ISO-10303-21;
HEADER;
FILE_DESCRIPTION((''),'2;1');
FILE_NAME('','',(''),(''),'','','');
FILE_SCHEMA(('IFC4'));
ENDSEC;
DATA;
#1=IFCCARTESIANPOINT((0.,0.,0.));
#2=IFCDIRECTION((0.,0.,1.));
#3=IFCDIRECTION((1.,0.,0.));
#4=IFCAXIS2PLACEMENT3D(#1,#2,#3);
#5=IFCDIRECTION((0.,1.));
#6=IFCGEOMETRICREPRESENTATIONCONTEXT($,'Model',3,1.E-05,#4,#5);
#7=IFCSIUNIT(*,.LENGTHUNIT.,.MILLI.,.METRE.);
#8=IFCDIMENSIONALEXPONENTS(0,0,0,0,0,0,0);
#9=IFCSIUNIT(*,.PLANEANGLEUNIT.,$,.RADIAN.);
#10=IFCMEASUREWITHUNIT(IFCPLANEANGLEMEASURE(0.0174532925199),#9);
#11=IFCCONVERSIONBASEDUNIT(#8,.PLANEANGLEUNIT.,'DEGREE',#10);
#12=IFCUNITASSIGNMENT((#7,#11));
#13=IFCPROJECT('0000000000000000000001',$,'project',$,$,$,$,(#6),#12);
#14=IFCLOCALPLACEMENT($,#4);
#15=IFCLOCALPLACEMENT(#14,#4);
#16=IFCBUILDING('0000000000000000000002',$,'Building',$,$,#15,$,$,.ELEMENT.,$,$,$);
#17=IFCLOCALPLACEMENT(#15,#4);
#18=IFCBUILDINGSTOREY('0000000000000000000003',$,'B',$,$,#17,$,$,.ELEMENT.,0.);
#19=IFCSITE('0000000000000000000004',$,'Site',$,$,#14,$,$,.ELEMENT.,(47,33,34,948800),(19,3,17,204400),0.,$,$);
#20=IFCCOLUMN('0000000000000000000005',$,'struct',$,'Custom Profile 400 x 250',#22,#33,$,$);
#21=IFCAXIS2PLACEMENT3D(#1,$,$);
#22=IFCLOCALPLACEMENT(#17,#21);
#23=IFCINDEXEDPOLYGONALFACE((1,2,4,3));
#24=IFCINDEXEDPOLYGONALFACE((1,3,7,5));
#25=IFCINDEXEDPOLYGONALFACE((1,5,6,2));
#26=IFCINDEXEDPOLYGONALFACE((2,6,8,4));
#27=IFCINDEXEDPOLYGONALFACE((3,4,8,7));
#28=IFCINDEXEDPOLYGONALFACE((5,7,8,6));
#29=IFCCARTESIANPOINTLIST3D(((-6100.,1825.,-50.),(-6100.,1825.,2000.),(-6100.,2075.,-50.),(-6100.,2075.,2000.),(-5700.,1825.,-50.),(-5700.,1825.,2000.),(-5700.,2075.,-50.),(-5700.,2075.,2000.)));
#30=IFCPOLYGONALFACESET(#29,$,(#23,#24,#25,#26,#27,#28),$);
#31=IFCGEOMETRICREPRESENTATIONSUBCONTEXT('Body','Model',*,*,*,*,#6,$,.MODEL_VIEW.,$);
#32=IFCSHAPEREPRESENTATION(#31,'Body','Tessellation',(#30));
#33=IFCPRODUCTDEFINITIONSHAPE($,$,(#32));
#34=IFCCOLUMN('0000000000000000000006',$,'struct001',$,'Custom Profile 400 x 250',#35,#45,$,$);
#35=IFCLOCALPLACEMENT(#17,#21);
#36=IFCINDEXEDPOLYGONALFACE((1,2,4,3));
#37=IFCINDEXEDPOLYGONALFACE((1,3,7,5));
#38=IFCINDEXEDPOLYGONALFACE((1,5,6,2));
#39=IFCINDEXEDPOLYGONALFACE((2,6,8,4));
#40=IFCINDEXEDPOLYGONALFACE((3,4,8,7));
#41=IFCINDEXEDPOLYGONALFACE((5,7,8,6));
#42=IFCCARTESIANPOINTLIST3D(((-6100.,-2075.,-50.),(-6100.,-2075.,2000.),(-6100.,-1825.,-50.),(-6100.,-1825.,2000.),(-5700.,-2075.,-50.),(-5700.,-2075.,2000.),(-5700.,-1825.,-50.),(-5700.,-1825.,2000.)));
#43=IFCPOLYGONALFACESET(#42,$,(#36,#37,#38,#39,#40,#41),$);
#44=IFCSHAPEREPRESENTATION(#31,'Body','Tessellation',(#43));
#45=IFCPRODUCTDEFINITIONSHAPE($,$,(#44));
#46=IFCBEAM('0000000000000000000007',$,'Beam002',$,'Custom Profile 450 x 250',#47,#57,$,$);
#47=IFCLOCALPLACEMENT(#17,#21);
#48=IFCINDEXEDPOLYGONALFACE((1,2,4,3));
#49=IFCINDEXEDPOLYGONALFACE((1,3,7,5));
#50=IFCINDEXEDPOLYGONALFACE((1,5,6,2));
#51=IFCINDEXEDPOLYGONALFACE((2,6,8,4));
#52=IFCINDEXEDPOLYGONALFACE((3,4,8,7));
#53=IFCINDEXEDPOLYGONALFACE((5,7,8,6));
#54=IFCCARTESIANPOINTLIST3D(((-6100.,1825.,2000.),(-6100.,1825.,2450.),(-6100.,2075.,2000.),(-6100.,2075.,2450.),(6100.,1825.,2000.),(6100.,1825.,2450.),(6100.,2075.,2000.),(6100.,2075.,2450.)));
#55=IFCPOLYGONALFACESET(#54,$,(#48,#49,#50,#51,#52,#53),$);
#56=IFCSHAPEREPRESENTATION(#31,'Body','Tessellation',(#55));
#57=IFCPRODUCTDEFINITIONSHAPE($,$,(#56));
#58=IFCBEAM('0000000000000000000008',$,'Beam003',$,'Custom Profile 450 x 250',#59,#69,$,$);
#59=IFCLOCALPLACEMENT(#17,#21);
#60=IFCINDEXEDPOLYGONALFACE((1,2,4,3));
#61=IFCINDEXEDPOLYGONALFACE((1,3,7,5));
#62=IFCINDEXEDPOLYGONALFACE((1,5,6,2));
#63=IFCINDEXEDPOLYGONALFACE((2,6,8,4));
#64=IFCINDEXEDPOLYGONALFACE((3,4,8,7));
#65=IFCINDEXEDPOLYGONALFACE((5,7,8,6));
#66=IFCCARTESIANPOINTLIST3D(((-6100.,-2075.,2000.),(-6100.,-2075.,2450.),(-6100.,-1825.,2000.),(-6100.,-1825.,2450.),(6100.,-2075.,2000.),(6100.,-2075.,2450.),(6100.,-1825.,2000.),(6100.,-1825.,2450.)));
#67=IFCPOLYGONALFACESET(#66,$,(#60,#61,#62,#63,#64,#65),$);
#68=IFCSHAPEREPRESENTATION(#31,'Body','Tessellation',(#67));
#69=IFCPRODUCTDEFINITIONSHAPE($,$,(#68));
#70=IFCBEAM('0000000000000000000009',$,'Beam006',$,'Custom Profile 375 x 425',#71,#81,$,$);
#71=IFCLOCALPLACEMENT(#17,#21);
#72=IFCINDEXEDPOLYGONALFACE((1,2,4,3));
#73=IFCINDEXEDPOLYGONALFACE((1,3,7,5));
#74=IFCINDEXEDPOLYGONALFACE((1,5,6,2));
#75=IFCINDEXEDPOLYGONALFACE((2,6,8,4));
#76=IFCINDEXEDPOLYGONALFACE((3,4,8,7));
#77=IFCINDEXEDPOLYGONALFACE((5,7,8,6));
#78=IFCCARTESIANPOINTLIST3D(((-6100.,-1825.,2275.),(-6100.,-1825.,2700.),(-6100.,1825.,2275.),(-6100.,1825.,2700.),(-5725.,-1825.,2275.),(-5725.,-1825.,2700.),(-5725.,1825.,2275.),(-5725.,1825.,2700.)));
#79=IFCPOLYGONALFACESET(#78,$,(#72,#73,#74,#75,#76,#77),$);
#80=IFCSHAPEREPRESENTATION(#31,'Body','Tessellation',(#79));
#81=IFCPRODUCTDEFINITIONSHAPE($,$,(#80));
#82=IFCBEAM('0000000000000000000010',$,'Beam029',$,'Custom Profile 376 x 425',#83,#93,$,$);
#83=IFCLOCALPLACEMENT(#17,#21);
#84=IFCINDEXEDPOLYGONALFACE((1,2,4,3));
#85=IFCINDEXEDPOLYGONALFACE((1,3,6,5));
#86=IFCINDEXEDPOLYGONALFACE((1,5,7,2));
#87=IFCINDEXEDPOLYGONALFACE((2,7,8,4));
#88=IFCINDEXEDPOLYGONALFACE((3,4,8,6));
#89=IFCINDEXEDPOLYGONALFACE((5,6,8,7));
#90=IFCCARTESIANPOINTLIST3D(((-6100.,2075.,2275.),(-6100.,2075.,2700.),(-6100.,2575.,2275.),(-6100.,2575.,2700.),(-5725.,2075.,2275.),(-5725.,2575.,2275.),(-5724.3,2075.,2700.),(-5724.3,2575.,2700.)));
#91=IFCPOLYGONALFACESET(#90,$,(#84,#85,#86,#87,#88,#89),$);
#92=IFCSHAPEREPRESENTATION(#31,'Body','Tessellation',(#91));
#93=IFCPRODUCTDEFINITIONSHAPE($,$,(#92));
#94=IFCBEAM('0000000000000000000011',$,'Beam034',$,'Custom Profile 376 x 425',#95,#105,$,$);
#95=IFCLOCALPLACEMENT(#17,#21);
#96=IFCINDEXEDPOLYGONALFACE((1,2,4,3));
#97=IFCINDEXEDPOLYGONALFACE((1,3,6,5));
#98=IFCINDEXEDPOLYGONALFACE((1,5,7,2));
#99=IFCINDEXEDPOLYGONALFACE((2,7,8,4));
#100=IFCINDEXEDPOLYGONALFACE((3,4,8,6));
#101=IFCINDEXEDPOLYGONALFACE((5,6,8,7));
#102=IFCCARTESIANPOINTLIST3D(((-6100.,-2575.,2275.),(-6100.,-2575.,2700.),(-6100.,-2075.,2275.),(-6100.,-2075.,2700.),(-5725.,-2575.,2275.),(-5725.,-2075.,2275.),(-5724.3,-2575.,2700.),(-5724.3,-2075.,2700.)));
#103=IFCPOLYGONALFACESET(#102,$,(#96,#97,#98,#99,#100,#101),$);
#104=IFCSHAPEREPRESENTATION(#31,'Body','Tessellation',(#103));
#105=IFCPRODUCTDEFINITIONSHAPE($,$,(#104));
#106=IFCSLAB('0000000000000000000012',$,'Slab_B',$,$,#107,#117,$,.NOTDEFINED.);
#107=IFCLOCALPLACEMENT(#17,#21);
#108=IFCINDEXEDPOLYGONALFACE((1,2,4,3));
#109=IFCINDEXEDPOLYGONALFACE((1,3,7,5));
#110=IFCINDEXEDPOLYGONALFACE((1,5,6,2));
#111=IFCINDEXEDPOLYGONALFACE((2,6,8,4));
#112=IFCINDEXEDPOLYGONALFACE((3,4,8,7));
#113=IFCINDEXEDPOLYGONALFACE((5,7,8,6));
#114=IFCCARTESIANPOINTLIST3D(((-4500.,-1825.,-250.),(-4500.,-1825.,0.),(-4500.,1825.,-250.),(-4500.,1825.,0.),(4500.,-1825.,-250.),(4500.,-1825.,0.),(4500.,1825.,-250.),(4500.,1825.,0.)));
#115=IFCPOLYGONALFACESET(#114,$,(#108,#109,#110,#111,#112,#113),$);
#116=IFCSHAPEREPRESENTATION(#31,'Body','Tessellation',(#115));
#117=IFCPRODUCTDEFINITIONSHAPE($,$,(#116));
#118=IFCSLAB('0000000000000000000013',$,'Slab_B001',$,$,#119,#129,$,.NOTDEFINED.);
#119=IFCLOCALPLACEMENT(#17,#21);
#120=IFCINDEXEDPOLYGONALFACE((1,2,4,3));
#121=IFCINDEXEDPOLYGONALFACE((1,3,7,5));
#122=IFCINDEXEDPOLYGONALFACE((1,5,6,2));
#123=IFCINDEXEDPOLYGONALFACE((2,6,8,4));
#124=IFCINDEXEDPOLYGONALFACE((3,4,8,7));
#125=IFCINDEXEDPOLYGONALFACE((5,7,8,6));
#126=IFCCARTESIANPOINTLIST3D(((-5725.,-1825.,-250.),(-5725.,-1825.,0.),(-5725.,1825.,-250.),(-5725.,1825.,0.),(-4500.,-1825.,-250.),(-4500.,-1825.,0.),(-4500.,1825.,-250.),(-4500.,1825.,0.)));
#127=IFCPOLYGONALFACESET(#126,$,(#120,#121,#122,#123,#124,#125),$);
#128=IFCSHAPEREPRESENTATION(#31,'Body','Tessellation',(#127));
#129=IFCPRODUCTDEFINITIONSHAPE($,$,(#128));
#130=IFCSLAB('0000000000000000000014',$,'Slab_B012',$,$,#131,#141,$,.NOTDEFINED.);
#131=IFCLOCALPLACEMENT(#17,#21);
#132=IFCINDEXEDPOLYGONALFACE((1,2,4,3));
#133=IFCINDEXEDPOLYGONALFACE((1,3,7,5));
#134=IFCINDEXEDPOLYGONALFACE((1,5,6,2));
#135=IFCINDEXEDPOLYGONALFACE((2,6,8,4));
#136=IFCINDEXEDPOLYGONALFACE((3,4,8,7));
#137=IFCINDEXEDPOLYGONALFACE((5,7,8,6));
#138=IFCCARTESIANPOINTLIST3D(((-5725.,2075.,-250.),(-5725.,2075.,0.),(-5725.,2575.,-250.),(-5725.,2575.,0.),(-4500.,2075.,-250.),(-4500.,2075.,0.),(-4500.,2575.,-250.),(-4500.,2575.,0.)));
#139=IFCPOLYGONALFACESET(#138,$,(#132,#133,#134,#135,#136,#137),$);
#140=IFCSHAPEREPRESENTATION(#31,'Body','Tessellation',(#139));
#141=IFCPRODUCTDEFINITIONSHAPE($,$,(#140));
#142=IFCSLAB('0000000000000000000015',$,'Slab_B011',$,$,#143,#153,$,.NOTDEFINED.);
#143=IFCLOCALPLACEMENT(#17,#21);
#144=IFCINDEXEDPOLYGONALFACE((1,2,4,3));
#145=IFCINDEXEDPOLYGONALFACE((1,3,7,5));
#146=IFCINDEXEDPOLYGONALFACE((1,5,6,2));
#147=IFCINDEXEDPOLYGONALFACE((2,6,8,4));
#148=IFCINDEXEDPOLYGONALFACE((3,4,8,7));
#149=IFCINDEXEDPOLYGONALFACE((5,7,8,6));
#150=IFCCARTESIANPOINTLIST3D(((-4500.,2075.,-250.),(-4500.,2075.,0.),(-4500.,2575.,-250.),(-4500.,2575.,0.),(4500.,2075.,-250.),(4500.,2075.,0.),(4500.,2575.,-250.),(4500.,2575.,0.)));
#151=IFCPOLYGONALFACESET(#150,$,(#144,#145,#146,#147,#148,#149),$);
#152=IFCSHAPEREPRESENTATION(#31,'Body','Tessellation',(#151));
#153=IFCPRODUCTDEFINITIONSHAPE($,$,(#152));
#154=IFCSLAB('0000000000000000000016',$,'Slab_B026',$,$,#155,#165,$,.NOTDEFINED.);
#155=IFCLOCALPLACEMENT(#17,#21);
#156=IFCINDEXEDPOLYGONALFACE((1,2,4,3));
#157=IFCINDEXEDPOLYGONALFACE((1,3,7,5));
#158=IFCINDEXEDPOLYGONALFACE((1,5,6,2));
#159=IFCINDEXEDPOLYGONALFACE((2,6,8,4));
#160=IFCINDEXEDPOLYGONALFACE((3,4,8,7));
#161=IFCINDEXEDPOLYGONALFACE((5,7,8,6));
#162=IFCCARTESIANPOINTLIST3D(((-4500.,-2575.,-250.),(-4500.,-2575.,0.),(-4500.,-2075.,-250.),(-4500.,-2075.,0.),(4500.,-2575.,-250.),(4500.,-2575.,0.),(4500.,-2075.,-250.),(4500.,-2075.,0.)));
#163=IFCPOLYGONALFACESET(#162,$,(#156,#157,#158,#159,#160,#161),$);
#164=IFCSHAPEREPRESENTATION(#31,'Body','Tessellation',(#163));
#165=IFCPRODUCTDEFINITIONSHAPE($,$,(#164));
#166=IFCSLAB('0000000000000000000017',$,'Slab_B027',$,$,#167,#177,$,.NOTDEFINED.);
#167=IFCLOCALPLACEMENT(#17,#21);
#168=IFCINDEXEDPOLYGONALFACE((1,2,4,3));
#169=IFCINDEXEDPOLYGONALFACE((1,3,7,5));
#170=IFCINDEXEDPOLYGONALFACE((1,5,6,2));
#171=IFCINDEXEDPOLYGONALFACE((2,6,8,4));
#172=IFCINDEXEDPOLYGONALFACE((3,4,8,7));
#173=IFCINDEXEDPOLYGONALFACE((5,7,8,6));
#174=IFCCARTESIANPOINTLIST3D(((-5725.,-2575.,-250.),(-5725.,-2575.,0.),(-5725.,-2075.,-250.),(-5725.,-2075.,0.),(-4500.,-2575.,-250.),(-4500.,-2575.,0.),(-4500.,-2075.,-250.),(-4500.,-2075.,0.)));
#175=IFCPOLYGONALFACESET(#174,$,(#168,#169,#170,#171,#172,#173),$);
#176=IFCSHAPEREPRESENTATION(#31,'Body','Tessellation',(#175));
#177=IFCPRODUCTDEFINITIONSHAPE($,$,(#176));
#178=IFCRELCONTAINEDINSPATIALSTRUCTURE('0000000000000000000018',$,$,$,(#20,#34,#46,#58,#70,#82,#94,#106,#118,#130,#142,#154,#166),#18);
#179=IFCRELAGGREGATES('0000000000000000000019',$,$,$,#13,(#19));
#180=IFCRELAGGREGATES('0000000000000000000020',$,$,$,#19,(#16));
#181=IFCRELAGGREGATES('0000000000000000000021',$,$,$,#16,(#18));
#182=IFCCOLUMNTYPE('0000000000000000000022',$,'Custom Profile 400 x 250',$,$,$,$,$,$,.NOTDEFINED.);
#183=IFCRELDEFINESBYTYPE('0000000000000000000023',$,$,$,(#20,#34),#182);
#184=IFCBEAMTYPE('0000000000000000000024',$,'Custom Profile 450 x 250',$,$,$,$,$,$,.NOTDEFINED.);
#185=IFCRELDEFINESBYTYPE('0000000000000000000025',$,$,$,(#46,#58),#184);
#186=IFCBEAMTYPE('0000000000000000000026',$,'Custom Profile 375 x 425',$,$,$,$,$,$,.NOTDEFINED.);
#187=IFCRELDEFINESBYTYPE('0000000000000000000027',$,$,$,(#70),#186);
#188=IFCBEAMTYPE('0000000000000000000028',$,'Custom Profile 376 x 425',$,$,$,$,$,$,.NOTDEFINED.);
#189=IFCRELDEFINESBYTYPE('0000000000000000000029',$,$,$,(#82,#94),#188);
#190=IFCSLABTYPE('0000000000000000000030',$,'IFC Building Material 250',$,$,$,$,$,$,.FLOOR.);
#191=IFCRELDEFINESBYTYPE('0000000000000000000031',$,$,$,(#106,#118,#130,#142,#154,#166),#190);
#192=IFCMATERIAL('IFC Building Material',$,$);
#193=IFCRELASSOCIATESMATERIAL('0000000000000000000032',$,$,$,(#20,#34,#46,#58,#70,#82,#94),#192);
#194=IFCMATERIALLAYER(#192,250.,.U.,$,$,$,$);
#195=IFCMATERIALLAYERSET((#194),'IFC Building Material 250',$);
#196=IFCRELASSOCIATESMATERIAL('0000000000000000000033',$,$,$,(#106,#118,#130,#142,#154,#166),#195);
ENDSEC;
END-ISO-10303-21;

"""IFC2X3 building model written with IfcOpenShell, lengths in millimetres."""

from ifc_helpers import new_model, entity, si_unit, converted_unit, direction, frame, origin_with_axes, place, context, subcontext, project, spatial, polyline, outline, extrude, material, layer, layer_set, layer_usage, type_object, element, save


model = new_model("IFC2X3")

# Units and contexts
model_context = context("Model", 3, precision=1e-05, world=origin_with_axes(), true_north=direction((0.0, 1.0)))
body_context = subcontext(model_context, "Body", "Model", "MODEL_VIEW")
ifc_project = project(units=[si_unit("LENGTHUNIT", "METRE", prefix="MILLI"), converted_unit("PLANEANGLEUNIT", "DEGREE", entity("IfcPlaneAngleMeasure", 0.0174532925199), si_unit("PLANEANGLEUNIT", "RADIAN"), dimensions=[0, 0, 0, 0, 0, 0, 0])], contexts=[model_context])

# Site, building, storey
site_placement = place(None, origin_with_axes())
site = spatial("IfcSite", under=ifc_project, at=site_placement, Name="Site", CompositionType="ELEMENT", RefLatitude=(47, 33, 34, 948800), RefLongitude=(19, 3, 17, 204400), RefElevation=0.0)
building_placement = place(site_placement, origin_with_axes())
building = spatial("IfcBuilding", under=site, at=building_placement, Name="Building", CompositionType="ELEMENT")
storey_placement = place(building_placement, origin_with_axes())
storey = spatial("IfcBuildingStorey", under=building, at=storey_placement, Name="B", CompositionType="ELEMENT", Elevation=0.0)

# Columns
ifc_material = material(Name="IFC Building Material")
column_type = type_object("IfcColumnType", Name="Custom Profile 400 x 250", PredefinedType="NOTDEFINED")
for number, where, z_axis, x_axis, name in (
    (1, (-5900.0, 1950.0, -50.0), (0.0, 0.0, 1.0), (1.0, 0.0, 0.0), "struct"),
    (2, (-5900.0, -1950.0, -50.0), (0.0, 0.0, 1.0), (1.0, 0.0, 0.0), "struct001"),
):
    element("IfcColumn", number, at=place(storey_placement, frame(where, z_axis=z_axis, x_axis=x_axis)), inside=storey, type_object=column_type, material=ifc_material, Name=name, ObjectType="Custom Profile 400 x 250", context=body_context, shape_type="SweptSolid", body=[
        extrude(outline(polyline([(-200.0, -125.0), (200.0, -125.0), (200.0, 125.0), (-200.0, 125.0), (-200.0, -125.0)])), origin_with_axes(), (0.0, 0.0, 1.0), 2050.0),
    ])

# Beams
beam_type_1 = type_object("IfcBeamType", Name="Custom Profile 450 x 250", PredefinedType="NOTDEFINED")
for number, where, z_axis, x_axis, name in (
    (3, (-6100.0, 1950.0, 2225.0), (0.0, 0.0, 1.0), (0.0, -1.0, 0.0), "Beam002"),
    (4, (-6100.0, -1950.0, 2225.0), (0.0, 0.0, 1.0), (0.0, -1.0, 0.0), "Beam003"),
):
    element("IfcBeam", number, at=place(storey_placement, frame(where, z_axis=z_axis, x_axis=x_axis)), inside=storey, type_object=beam_type_1, material=ifc_material, Name=name, ObjectType="Custom Profile 450 x 250", context=body_context, shape_type="SweptSolid", body=[
        extrude(outline(polyline([(-125.0, -225.0), (125.0, -225.0), (125.0, 225.0), (-125.0, 225.0), (-125.0, -225.0)])), frame((0.0, 12200.0, 0.0), z_axis=(0.0, -1.0, 0.0), x_axis=(1.0, 0.0, 0.0)), (0.0, 0.0, 1.0), 12200.0),
    ])
beam_type_2 = type_object("IfcBeamType", Name="Custom Profile 375 x 425", PredefinedType="NOTDEFINED")
beam_placement = place(storey_placement, frame((-5912.3, -1825.0, 2487.6), z_axis=(0.0, 0.0, 1.0), x_axis=(1.0, 0.0, 0.0)))
element("IfcBeam", 5, at=beam_placement, inside=storey, type_object=beam_type_2, material=ifc_material, Name="Beam006", ObjectType="Custom Profile 375 x 425", context=body_context, shape_type="SweptSolid", body=[
    extrude(outline(polyline([(-187.7, -212.6), (187.3, -212.6), (187.3, 212.4), (-187.7, 212.4), (-187.7, -212.6)])), frame((0.0, 3650.0, 0.0), z_axis=(0.0, -1.0, 0.0), x_axis=(1.0, 0.0, 0.0)), (0.0, 0.0, 1.0), 3650.0),
])
beam_type_3 = type_object("IfcBeamType", Name="Custom Profile 376 x 425", PredefinedType="NOTDEFINED")
for number, where, z_axis, x_axis, name in (
    (6, (-5912.3, 2075.0, 2487.6), (0.0, 0.0, 1.0), (1.0, 0.0, 0.0), "Beam029"),
    (7, (-5912.3, -2575.0, 2487.6), (0.0, 0.0, 1.0), (1.0, 0.0, 0.0), "Beam034"),
):
    element("IfcBeam", number, at=place(storey_placement, frame(where, z_axis=z_axis, x_axis=x_axis)), inside=storey, type_object=beam_type_3, material=ifc_material, Name=name, ObjectType="Custom Profile 376 x 425", context=body_context, shape_type="SweptSolid", body=[
        extrude(outline(polyline([(-187.7, -212.6), (187.3, -212.6), (188.0, 212.4), (-187.7, 212.4), (-187.7, -212.6)])), frame((0.0, 500.0, 0.0), z_axis=(0.0, -1.0, 0.0), x_axis=(1.0, 0.0, 0.0)), (0.0, 0.0, 1.0), 500.0),
    ])

# Slabs
ifc_layer_1 = layer(ifc_material, 250.0, ventilated="UNKNOWN")
ifc_layer_set_1 = layer_set([ifc_layer_1], Name="IFC Building Material 250")
ifc_layer_usage_1 = layer_usage(ifc_layer_set_1, "AXIS3", "NEGATIVE", 250.0)
slab_type_1 = type_object("IfcSlabType", Name="IFC Building Material 250", PredefinedType="FLOOR")
slab_1_placement = place(storey_placement, frame((-4500.0, -1825.0, 0.0), z_axis=(0.0, 0.0, 1.0), x_axis=(1.0, 0.0, 0.0)))
element("IfcSlab", 8, at=slab_1_placement, inside=storey, type_object=slab_type_1, material=ifc_layer_usage_1, Name="Slab_B", PredefinedType="NOTDEFINED", context=body_context, shape_type="SweptSolid", body=[
    extrude(outline(polyline([(0.0, 0.0), (9000.0, 0.0), (9000.0, 3650.0), (0.0, 3650.0), (0.0, 0.0)])), frame((0.0, 0.0, -250.0), z_axis=(0.0, 0.0, 1.0), x_axis=(1.0, 0.0, 0.0)), (0.0, 0.0, 1.0), 250.0),
])
ifc_layer_usage_2 = layer_usage(ifc_layer_set_1, "AXIS3", "NEGATIVE", 250.0)
slab_2_placement = place(storey_placement, frame((-5725.0, -1825.0, 0.0), z_axis=(0.0, 0.0, 1.0), x_axis=(1.0, 0.0, 0.0)))
element("IfcSlab", 9, at=slab_2_placement, inside=storey, type_object=slab_type_1, material=ifc_layer_usage_2, Name="Slab_B001", PredefinedType="NOTDEFINED", context=body_context, shape_type="SweptSolid", body=[
    extrude(outline(polyline([(0.0, 0.0), (1225.0, 0.0), (1225.0, 3650.0), (0.0, 3650.0), (0.0, 0.0)])), frame((0.0, 0.0, -250.0), z_axis=(0.0, 0.0, 1.0), x_axis=(1.0, 0.0, 0.0)), (0.0, 0.0, 1.0), 250.0),
])
ifc_layer_usage_3 = layer_usage(ifc_layer_set_1, "AXIS3", "NEGATIVE", 250.0)
slab_3_placement = place(storey_placement, frame((-5725.0, 2575.0, 0.0), z_axis=(0.0, 0.0, 1.0), x_axis=(1.0, 0.0, 0.0)))
element("IfcSlab", 10, at=slab_3_placement, inside=storey, type_object=slab_type_1, material=ifc_layer_usage_3, Name="Slab_B012", PredefinedType="NOTDEFINED", context=body_context, shape_type="SweptSolid", body=[
    extrude(outline(polyline([(0.0, 0.0), (0.0, -500.0), (1225.0, -500.0), (1225.0, 0.0), (0.0, 0.0)])), frame((0.0, 0.0, -250.0), z_axis=(0.0, 0.0, 1.0), x_axis=(1.0, 0.0, 0.0)), (0.0, 0.0, 1.0), 250.0),
])
ifc_layer_usage_4 = layer_usage(ifc_layer_set_1, "AXIS3", "NEGATIVE", 250.0)
slab_4_placement = place(storey_placement, frame((-4500.0, 2575.0, 0.0), z_axis=(0.0, 0.0, 1.0), x_axis=(1.0, 0.0, 0.0)))
element("IfcSlab", 11, at=slab_4_placement, inside=storey, type_object=slab_type_1, material=ifc_layer_usage_4, Name="Slab_B011", PredefinedType="NOTDEFINED", context=body_context, shape_type="SweptSolid", body=[
    extrude(outline(polyline([(0.0, 0.0), (0.0, -500.0), (9000.0, -500.0), (9000.0, 0.0), (0.0, 0.0)])), frame((0.0, 0.0, -250.0), z_axis=(0.0, 0.0, 1.0), x_axis=(1.0, 0.0, 0.0)), (0.0, 0.0, 1.0), 250.0),
])
ifc_layer_usage_5 = layer_usage(ifc_layer_set_1, "AXIS3", "NEGATIVE", 250.0)
slab_5_placement = place(storey_placement, frame((-4500.0, -2575.0, 0.0), z_axis=(0.0, 0.0, 1.0), x_axis=(1.0, 0.0, 0.0)))
element("IfcSlab", 12, at=slab_5_placement, inside=storey, type_object=slab_type_1, material=ifc_layer_usage_5, Name="Slab_B026", PredefinedType="NOTDEFINED", context=body_context, shape_type="SweptSolid", body=[
    extrude(outline(polyline([(0.0, 0.0), (9000.0, 0.0), (9000.0, 500.0), (0.0, 500.0), (0.0, 0.0)])), frame((0.0, 0.0, -250.0), z_axis=(0.0, 0.0, 1.0), x_axis=(1.0, 0.0, 0.0)), (0.0, 0.0, 1.0), 250.0),
])
ifc_layer_usage_6 = layer_usage(ifc_layer_set_1, "AXIS3", "NEGATIVE", 250.0)
slab_6_placement = place(storey_placement, frame((-5725.0, -2575.0, 0.0), z_axis=(0.0, 0.0, 1.0), x_axis=(1.0, 0.0, 0.0)))
element("IfcSlab", 13, at=slab_6_placement, inside=storey, type_object=slab_type_1, material=ifc_layer_usage_6, Name="Slab_B027", PredefinedType="NOTDEFINED", context=body_context, shape_type="SweptSolid", body=[
    extrude(outline(polyline([(0.0, 0.0), (1225.0, 0.0), (1225.0, 500.0), (0.0, 500.0), (0.0, 0.0)])), frame((0.0, 0.0, -250.0), z_axis=(0.0, 0.0, 1.0), x_axis=(1.0, 0.0, 0.0)), (0.0, 0.0, 1.0), 250.0),
])

save(model, "model.ifc")
